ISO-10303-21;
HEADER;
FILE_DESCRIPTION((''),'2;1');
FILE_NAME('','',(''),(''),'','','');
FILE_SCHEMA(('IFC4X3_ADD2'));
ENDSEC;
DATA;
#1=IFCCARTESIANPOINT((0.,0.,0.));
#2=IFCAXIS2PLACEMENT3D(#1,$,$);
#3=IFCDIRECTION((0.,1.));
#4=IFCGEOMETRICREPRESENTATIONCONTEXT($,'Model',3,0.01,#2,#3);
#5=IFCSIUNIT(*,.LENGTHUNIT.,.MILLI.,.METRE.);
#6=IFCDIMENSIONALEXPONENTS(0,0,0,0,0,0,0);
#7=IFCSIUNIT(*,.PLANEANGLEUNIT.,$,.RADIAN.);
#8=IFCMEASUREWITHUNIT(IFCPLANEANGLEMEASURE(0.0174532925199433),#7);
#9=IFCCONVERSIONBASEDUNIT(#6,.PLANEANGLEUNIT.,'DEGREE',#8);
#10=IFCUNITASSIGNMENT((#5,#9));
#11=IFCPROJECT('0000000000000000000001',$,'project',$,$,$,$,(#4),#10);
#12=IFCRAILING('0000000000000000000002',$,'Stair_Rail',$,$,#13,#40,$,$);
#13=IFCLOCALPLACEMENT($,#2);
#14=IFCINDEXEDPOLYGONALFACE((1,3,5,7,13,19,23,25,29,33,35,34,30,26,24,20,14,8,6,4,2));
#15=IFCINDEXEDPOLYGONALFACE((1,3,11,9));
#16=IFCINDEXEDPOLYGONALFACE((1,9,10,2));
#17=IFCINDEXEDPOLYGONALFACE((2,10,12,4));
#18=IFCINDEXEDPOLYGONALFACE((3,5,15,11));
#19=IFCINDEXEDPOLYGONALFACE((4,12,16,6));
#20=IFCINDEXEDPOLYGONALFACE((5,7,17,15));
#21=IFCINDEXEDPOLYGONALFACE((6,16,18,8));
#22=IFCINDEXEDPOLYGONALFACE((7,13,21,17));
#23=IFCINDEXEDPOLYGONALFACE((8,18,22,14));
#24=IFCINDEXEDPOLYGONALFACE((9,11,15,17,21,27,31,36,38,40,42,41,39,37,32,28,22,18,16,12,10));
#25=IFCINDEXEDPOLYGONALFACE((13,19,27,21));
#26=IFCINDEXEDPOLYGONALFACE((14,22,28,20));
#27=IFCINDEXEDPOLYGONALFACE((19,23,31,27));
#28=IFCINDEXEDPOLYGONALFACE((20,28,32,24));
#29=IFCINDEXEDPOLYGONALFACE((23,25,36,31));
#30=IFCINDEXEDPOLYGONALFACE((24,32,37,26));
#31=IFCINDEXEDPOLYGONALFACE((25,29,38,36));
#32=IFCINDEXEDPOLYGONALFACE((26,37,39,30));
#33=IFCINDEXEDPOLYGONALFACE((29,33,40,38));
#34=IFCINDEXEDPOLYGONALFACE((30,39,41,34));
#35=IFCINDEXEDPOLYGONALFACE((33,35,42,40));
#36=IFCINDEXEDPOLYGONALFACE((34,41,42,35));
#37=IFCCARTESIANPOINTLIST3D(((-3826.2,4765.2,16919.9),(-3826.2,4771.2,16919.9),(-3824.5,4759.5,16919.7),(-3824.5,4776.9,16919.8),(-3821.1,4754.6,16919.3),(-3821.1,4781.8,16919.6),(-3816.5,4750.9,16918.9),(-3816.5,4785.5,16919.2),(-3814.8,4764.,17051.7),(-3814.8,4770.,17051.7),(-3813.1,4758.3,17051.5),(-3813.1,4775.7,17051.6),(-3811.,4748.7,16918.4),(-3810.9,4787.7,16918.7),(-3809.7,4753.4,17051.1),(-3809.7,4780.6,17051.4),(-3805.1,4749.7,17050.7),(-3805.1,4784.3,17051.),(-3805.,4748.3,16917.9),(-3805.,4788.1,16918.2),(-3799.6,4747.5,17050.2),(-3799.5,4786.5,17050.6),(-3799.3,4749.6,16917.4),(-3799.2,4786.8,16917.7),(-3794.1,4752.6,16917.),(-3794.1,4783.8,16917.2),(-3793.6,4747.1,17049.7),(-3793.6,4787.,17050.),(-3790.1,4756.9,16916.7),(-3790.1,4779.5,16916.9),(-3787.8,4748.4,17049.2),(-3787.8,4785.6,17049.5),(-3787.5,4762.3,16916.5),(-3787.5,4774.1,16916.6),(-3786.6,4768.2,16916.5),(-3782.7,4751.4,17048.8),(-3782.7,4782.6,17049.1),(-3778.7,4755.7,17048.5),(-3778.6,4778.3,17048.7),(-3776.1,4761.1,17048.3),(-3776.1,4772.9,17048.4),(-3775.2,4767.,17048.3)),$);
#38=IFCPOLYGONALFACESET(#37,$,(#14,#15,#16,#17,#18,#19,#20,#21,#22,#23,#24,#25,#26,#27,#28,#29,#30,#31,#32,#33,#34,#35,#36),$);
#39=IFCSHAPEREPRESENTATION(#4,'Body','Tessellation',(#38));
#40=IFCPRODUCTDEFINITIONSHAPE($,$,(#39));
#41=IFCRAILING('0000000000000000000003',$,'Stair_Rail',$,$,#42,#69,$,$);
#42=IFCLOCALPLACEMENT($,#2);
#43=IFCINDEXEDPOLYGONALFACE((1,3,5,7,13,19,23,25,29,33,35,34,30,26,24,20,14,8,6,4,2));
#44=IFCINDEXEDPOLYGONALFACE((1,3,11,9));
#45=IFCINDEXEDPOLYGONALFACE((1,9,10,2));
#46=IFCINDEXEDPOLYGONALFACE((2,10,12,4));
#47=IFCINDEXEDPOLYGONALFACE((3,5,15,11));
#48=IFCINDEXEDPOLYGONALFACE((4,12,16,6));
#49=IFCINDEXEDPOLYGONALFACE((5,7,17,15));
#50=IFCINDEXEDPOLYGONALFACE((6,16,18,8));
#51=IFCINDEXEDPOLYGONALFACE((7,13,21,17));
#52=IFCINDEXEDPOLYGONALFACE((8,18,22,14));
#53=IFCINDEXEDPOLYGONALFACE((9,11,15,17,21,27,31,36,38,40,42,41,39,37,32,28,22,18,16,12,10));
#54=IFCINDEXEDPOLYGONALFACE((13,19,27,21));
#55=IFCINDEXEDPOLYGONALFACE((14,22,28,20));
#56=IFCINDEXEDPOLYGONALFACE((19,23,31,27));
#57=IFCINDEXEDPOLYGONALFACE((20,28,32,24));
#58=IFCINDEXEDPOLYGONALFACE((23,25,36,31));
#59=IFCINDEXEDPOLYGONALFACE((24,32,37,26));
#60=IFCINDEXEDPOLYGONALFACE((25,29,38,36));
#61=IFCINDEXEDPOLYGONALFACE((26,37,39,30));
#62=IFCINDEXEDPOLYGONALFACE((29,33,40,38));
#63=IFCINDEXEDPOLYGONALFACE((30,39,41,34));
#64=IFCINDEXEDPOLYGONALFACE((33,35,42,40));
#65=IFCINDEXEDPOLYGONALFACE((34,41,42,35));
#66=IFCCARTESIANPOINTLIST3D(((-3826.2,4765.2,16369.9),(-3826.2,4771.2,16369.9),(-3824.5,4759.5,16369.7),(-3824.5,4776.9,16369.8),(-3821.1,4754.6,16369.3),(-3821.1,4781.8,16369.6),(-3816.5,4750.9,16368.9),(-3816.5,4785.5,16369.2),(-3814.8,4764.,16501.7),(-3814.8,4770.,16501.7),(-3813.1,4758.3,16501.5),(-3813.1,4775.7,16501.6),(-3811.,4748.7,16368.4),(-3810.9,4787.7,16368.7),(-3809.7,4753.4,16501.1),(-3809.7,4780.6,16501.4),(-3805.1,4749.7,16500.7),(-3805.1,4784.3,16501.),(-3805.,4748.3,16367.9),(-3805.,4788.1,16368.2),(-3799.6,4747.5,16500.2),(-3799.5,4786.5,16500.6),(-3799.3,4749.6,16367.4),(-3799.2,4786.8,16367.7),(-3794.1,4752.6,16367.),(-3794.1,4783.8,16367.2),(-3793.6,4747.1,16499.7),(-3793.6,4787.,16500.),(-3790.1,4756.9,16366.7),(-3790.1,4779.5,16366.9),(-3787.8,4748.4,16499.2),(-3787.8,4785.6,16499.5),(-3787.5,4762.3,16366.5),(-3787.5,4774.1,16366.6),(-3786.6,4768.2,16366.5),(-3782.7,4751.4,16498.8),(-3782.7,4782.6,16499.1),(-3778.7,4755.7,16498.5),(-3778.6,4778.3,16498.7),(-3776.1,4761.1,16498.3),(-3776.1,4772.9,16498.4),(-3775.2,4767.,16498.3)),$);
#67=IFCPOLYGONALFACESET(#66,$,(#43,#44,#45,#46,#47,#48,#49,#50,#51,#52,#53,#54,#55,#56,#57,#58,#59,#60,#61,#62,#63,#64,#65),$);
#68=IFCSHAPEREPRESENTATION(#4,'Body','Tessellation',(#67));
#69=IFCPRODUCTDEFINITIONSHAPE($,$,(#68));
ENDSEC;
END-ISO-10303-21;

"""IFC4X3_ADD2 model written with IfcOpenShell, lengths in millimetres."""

from ifc_helpers import new_model, entity, si_unit, converted_unit, direction, origin, context, project, element, save


model = new_model("IFC4X3_ADD2")

# Units and contexts
model_context = context("Model", 3, precision=0.01, world=origin(), true_north=direction((0.0, 1.0)))
ifc_project = project(units=[si_unit("LENGTHUNIT", "METRE", prefix="MILLI"), converted_unit("PLANEANGLEUNIT", "DEGREE", entity("IfcPlaneAngleMeasure", 0.0174532925199433), si_unit("PLANEANGLEUNIT", "RADIAN"), dimensions=[0, 0, 0, 0, 0, 0, 0])], contexts=[model_context])

# Railings
element("IfcRailing", 1, Name="Stair_Rail", context=model_context, shape_type="SweptSolid", body=[
    entity("IfcSweptDiskSolid", entity("IfcPolyline", [entity("IfcCartesianPoint", [-3806.5, 4768.2, 16918.2]), entity("IfcCartesianPoint", [-3795.1, 4767.0, 17050.0])]), 20.0),
])
element("IfcRailing", 2, Name="Stair_Rail", context=model_context, shape_type="SweptSolid", body=[
    entity("IfcSweptDiskSolid", entity("IfcPolyline", [entity("IfcCartesianPoint", [-3806.5, 4768.2, 16368.2]), entity("IfcCartesianPoint", [-3795.1, 4767.0, 16500.0])]), 20.0),
])

save(model, "model.ifc")
